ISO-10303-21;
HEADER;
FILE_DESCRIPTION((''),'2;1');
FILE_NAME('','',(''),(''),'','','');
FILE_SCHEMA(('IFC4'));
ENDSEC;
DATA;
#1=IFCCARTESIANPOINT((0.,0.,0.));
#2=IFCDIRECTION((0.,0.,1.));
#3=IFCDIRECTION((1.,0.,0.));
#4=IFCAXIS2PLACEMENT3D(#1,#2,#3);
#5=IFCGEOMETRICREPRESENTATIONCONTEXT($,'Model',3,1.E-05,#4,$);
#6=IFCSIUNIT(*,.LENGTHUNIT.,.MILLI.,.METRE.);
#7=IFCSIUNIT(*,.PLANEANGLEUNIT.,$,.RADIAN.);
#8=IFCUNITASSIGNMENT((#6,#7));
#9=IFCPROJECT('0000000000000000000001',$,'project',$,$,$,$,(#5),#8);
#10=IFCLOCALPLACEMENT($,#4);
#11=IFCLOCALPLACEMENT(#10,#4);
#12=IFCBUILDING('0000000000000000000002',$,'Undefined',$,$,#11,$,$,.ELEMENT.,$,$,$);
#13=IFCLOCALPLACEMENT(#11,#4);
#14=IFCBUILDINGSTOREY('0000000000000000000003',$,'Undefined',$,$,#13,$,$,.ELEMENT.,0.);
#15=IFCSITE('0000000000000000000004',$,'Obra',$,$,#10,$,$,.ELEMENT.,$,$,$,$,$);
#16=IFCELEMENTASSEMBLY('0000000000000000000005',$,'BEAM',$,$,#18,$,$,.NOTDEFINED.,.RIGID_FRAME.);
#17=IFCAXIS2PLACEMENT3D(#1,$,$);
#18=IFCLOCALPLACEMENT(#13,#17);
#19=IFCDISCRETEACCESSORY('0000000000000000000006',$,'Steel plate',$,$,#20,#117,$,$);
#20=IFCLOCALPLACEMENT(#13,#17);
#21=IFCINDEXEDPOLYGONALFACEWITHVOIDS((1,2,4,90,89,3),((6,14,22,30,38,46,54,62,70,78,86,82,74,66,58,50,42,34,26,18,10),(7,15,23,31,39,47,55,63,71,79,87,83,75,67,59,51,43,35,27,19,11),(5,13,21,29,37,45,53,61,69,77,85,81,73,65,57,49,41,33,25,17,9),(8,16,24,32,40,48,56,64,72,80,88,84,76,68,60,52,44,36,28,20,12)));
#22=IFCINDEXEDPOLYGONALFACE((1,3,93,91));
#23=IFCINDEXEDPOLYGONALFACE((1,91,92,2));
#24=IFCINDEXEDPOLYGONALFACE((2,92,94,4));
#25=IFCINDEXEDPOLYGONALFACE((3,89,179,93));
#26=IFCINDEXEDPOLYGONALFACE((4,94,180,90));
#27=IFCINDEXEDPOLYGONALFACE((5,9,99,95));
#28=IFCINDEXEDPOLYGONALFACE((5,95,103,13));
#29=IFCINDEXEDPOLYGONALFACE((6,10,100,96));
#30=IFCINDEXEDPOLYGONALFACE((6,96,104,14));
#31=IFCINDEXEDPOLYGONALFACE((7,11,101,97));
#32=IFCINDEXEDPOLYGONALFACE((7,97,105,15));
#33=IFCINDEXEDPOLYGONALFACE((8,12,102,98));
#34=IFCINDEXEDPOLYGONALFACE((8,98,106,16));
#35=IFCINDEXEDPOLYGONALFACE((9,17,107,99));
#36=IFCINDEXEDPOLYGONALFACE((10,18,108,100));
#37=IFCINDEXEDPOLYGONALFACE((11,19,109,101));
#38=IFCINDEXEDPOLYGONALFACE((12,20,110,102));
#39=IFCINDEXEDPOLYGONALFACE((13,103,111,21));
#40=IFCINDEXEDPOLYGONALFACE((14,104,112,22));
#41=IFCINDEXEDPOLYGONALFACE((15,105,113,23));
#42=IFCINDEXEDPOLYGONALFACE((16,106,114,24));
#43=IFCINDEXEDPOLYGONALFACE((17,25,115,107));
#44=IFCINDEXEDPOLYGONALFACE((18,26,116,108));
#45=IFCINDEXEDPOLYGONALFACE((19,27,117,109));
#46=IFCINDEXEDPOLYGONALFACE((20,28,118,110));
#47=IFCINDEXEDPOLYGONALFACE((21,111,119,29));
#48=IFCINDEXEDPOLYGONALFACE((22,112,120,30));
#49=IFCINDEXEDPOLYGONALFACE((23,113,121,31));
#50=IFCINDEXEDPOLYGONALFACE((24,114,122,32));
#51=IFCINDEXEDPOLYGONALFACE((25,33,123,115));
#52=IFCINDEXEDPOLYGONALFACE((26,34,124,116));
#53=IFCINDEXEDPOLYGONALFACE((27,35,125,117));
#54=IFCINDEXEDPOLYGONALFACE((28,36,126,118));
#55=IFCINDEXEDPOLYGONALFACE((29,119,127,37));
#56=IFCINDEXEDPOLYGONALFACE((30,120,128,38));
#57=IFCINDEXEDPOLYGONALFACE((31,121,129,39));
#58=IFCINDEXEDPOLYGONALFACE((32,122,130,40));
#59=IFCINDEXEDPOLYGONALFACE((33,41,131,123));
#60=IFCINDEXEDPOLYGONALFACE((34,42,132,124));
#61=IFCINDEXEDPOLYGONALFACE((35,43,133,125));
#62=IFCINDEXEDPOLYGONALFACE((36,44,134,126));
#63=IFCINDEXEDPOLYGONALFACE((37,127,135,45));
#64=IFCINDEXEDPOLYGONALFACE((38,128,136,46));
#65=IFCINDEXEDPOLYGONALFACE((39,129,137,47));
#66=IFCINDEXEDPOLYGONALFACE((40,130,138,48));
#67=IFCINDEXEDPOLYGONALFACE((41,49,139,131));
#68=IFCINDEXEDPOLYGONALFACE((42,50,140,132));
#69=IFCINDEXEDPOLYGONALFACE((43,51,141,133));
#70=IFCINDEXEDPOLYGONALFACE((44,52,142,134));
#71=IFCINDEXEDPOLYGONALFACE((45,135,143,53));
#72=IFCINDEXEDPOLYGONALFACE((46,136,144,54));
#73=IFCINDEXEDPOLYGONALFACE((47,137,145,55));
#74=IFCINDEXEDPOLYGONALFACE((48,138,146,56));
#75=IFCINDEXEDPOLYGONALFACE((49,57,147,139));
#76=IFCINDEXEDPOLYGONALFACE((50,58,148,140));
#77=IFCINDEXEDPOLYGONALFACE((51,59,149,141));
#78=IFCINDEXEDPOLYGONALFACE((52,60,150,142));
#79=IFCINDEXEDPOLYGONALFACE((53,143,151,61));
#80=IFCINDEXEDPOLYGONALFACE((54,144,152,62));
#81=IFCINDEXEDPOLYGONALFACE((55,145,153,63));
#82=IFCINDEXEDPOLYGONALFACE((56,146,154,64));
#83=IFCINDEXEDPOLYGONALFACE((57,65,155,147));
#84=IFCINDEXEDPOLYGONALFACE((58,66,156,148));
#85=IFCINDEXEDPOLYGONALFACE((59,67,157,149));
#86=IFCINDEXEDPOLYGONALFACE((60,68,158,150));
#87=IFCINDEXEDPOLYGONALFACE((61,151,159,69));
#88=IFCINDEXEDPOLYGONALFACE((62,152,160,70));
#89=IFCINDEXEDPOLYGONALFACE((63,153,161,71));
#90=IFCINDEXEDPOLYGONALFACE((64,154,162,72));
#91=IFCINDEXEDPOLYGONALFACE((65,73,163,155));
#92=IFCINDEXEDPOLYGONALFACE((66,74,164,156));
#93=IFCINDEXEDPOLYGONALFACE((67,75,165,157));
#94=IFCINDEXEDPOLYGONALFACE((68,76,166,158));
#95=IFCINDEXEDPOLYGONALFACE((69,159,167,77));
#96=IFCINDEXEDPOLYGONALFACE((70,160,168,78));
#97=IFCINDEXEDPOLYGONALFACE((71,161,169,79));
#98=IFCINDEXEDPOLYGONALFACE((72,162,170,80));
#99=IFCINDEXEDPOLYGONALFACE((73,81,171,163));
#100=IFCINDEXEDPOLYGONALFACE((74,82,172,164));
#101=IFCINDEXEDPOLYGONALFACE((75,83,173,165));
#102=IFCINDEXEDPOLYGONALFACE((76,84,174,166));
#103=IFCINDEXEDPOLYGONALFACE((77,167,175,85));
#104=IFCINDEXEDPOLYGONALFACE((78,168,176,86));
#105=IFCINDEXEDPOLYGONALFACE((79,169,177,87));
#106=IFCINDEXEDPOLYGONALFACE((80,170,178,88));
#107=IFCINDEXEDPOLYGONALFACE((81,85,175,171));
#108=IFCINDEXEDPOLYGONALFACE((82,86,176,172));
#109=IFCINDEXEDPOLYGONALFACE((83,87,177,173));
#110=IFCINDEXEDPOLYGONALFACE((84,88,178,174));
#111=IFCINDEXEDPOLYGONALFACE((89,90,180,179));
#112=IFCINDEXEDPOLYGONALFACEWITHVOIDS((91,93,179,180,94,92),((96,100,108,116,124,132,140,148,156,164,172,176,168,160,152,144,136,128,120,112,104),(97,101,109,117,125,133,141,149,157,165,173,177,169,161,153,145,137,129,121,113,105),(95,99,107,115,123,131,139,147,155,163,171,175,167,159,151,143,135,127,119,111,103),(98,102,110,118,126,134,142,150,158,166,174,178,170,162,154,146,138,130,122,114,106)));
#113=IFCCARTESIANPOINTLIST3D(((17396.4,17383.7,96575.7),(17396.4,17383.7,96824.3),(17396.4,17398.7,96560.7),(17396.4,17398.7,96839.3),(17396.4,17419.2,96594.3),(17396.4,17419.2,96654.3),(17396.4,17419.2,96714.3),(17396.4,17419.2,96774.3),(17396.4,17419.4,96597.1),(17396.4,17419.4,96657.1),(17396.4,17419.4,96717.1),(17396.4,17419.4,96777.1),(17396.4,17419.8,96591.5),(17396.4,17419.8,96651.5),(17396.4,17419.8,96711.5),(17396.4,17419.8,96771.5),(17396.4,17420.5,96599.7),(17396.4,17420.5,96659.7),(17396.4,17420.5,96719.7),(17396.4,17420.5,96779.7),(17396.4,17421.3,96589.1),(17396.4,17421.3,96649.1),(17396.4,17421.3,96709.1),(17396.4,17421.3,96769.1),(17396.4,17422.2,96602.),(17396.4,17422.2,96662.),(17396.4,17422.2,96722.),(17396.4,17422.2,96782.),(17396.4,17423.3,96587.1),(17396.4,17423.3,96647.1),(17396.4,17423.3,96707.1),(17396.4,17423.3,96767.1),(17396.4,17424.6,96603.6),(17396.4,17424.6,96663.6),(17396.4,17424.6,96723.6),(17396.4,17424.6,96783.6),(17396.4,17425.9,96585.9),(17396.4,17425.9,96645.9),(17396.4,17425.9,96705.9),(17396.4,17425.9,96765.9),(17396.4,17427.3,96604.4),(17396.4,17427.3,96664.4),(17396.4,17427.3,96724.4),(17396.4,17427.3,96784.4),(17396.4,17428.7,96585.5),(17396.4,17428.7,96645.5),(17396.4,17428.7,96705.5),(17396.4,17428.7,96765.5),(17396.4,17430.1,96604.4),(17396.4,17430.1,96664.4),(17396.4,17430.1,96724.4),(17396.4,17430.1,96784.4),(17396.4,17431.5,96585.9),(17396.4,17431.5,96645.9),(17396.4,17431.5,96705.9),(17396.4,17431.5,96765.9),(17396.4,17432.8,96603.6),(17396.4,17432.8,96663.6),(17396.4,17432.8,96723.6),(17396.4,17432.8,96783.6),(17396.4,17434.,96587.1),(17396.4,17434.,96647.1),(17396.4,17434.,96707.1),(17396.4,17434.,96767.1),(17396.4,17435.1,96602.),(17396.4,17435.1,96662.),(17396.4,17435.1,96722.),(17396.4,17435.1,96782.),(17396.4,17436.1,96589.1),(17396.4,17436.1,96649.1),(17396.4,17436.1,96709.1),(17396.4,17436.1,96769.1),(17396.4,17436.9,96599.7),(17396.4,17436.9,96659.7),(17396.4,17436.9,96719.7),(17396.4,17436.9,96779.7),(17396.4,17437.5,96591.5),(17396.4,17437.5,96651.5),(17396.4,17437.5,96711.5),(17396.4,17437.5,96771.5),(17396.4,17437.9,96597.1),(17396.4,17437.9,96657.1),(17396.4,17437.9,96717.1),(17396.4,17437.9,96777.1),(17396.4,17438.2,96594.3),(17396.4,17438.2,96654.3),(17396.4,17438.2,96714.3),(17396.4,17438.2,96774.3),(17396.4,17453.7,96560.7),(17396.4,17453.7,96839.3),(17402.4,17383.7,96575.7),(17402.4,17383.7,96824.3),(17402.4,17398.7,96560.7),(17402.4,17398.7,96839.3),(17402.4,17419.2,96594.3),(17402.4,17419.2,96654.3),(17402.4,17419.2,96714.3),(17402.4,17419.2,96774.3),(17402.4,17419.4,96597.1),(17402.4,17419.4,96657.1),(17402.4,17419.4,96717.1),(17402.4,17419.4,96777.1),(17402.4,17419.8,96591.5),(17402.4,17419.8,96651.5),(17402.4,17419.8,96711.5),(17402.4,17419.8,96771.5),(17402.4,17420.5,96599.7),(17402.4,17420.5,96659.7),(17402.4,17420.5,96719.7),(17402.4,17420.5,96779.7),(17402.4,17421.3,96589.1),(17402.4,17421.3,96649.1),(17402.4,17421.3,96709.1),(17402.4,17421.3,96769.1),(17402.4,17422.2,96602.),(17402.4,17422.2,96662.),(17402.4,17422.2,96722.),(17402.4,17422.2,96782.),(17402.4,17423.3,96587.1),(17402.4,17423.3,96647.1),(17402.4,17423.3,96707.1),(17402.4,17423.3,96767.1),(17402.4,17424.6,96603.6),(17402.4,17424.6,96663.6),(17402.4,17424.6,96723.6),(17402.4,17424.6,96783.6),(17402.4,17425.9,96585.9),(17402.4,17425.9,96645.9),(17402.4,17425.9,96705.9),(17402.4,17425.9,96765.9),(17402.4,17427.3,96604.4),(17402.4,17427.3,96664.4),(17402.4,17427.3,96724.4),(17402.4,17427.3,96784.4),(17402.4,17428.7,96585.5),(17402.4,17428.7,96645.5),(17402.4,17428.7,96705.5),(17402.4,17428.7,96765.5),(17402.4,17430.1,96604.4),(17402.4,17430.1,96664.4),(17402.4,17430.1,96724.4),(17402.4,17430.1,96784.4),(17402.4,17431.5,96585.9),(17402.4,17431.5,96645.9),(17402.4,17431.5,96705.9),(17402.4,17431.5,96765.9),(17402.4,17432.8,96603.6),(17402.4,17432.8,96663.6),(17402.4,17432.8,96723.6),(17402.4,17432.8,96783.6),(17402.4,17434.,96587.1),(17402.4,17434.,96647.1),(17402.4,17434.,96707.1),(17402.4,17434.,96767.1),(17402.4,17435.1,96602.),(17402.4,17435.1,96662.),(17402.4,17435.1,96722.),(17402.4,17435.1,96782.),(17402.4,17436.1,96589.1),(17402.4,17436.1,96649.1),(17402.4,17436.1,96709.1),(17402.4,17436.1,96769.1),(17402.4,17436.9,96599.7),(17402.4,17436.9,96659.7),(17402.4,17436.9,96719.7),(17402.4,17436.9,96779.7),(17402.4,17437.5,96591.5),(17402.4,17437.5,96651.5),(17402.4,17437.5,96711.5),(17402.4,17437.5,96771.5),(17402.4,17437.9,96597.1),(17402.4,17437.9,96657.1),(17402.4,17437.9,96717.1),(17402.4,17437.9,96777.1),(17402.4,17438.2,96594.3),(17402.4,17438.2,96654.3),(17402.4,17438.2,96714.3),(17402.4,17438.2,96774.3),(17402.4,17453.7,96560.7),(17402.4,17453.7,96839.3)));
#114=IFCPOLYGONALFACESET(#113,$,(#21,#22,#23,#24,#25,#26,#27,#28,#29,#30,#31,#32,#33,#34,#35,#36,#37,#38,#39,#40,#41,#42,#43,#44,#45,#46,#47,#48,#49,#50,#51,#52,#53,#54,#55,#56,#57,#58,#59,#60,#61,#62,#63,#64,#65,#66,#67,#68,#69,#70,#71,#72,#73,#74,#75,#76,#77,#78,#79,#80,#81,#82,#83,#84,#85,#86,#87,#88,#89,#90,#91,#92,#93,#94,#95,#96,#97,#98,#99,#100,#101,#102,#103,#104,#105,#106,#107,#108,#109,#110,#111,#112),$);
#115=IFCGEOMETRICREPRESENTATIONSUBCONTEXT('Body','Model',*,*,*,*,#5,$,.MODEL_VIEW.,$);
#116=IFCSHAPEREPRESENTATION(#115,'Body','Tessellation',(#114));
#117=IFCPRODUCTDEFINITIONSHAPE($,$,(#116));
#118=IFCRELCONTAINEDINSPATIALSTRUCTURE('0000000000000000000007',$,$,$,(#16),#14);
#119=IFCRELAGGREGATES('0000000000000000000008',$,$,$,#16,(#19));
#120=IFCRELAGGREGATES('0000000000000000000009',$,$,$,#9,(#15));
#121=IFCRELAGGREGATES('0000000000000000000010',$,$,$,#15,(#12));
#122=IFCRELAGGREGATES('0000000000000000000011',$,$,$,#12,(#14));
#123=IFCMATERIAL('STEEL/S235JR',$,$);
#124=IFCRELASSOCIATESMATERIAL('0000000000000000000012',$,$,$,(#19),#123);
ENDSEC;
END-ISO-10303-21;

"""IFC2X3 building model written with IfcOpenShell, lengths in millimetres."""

from ifc_helpers import new_model, si_unit, frame, origin_with_axes, origin_2d_with_axis, place, context, subcontext, project, spatial, polyline, circle, outline, extrude, source, transform, mapped, material, element, aggregate, save


model = new_model("IFC2X3")

# Units and contexts
model_context = context("Model", 3, precision=1e-05, world=origin_with_axes())
body_context = subcontext(model_context, "Body", "Model", "MODEL_VIEW")
ifc_project = project(units=[si_unit("LENGTHUNIT", "METRE", prefix="MILLI"), si_unit("PLANEANGLEUNIT", "RADIAN")], contexts=[model_context])

# Site, building, storey
site_placement = place(None, origin_with_axes())
site = spatial("IfcSite", under=ifc_project, at=site_placement, Name="Obra", CompositionType="ELEMENT")
building_placement = place(site_placement, origin_with_axes())
building = spatial("IfcBuilding", under=site, at=building_placement, Name="Undefined", CompositionType="ELEMENT")
storey_placement = place(building_placement, origin_with_axes())
storey = spatial("IfcBuildingStorey", under=building, at=storey_placement, Name="Undefined", CompositionType="ELEMENT", Elevation=0.0)

# Element assembly, discrete accessory, opening
assembly_1_placement = place(storey_placement, origin_with_axes())
assembly_1 = element("IfcElementAssembly", 1, at=assembly_1_placement, inside=storey, Name="BEAM", AssemblyPlace="NOTDEFINED", PredefinedType="RIGID_FRAME")
ifc_material_1 = material(Name="STEEL/S235JR")
discrete_accessory_1_placement = place(assembly_1_placement, frame((17399.4, 17453.7, 96560.7), z_axis=(-1.0, 0.0, 0.0), x_axis=(0.0, -1.0, 0.0)))
discrete_accessory_1 = element("IfcDiscreteAccessory", 2, at=discrete_accessory_1_placement, material=ifc_material_1, Name="Steel plate", context=body_context, shape_type="SweptSolid", body=[
    extrude(outline(polyline([(0.0, 0.0), (55.0, 0.0), (70.0, 15.0), (70.0, 263.6), (55.0, 278.6), (0.0, 278.6), (0.0, 0.0)])), frame((0.0, 0.0, -3.0), z_axis=(0.0, 0.0, 1.0), x_axis=(1.0, 0.0, 0.0)), (0.0, 0.0, 1.0), 6.0),
])
shared_shape_1 = source(origin_with_axes(), body_context, "Body", "SweptSolid", [
    extrude(circle(Radius=9.5, at=origin_2d_with_axis()), frame((0.0, -9.8, 0.0), z_axis=(0.0, 1.0, 0.0), x_axis=(1.0, 0.0, 0.0)), (0.0, 0.0, 1.0), 6.2),
])
opening_1_placement = place(assembly_1_placement, frame((17392.7, 17393.7, 96850.0), z_axis=(0.0, 1.0, 0.0), x_axis=(0.0, 0.0, -1.0)))
element("IfcOpeningElement", 3, at=opening_1_placement, cuts=discrete_accessory_1, ObjectType="Opening", context=body_context, shape_type="MappedRepresentation", body=[
    mapped(shared_shape_1, transform((75.0, 0.0, 35.0))),
    mapped(shared_shape_1, transform((135.0, 0.0, 35.0))),
    mapped(shared_shape_1, transform((195.0, 0.0, 35.0))),
    mapped(shared_shape_1, transform((255.0, 0.0, 35.0))),
])

aggregate(assembly_1, [discrete_accessory_1])

save(model, "model.ifc")
